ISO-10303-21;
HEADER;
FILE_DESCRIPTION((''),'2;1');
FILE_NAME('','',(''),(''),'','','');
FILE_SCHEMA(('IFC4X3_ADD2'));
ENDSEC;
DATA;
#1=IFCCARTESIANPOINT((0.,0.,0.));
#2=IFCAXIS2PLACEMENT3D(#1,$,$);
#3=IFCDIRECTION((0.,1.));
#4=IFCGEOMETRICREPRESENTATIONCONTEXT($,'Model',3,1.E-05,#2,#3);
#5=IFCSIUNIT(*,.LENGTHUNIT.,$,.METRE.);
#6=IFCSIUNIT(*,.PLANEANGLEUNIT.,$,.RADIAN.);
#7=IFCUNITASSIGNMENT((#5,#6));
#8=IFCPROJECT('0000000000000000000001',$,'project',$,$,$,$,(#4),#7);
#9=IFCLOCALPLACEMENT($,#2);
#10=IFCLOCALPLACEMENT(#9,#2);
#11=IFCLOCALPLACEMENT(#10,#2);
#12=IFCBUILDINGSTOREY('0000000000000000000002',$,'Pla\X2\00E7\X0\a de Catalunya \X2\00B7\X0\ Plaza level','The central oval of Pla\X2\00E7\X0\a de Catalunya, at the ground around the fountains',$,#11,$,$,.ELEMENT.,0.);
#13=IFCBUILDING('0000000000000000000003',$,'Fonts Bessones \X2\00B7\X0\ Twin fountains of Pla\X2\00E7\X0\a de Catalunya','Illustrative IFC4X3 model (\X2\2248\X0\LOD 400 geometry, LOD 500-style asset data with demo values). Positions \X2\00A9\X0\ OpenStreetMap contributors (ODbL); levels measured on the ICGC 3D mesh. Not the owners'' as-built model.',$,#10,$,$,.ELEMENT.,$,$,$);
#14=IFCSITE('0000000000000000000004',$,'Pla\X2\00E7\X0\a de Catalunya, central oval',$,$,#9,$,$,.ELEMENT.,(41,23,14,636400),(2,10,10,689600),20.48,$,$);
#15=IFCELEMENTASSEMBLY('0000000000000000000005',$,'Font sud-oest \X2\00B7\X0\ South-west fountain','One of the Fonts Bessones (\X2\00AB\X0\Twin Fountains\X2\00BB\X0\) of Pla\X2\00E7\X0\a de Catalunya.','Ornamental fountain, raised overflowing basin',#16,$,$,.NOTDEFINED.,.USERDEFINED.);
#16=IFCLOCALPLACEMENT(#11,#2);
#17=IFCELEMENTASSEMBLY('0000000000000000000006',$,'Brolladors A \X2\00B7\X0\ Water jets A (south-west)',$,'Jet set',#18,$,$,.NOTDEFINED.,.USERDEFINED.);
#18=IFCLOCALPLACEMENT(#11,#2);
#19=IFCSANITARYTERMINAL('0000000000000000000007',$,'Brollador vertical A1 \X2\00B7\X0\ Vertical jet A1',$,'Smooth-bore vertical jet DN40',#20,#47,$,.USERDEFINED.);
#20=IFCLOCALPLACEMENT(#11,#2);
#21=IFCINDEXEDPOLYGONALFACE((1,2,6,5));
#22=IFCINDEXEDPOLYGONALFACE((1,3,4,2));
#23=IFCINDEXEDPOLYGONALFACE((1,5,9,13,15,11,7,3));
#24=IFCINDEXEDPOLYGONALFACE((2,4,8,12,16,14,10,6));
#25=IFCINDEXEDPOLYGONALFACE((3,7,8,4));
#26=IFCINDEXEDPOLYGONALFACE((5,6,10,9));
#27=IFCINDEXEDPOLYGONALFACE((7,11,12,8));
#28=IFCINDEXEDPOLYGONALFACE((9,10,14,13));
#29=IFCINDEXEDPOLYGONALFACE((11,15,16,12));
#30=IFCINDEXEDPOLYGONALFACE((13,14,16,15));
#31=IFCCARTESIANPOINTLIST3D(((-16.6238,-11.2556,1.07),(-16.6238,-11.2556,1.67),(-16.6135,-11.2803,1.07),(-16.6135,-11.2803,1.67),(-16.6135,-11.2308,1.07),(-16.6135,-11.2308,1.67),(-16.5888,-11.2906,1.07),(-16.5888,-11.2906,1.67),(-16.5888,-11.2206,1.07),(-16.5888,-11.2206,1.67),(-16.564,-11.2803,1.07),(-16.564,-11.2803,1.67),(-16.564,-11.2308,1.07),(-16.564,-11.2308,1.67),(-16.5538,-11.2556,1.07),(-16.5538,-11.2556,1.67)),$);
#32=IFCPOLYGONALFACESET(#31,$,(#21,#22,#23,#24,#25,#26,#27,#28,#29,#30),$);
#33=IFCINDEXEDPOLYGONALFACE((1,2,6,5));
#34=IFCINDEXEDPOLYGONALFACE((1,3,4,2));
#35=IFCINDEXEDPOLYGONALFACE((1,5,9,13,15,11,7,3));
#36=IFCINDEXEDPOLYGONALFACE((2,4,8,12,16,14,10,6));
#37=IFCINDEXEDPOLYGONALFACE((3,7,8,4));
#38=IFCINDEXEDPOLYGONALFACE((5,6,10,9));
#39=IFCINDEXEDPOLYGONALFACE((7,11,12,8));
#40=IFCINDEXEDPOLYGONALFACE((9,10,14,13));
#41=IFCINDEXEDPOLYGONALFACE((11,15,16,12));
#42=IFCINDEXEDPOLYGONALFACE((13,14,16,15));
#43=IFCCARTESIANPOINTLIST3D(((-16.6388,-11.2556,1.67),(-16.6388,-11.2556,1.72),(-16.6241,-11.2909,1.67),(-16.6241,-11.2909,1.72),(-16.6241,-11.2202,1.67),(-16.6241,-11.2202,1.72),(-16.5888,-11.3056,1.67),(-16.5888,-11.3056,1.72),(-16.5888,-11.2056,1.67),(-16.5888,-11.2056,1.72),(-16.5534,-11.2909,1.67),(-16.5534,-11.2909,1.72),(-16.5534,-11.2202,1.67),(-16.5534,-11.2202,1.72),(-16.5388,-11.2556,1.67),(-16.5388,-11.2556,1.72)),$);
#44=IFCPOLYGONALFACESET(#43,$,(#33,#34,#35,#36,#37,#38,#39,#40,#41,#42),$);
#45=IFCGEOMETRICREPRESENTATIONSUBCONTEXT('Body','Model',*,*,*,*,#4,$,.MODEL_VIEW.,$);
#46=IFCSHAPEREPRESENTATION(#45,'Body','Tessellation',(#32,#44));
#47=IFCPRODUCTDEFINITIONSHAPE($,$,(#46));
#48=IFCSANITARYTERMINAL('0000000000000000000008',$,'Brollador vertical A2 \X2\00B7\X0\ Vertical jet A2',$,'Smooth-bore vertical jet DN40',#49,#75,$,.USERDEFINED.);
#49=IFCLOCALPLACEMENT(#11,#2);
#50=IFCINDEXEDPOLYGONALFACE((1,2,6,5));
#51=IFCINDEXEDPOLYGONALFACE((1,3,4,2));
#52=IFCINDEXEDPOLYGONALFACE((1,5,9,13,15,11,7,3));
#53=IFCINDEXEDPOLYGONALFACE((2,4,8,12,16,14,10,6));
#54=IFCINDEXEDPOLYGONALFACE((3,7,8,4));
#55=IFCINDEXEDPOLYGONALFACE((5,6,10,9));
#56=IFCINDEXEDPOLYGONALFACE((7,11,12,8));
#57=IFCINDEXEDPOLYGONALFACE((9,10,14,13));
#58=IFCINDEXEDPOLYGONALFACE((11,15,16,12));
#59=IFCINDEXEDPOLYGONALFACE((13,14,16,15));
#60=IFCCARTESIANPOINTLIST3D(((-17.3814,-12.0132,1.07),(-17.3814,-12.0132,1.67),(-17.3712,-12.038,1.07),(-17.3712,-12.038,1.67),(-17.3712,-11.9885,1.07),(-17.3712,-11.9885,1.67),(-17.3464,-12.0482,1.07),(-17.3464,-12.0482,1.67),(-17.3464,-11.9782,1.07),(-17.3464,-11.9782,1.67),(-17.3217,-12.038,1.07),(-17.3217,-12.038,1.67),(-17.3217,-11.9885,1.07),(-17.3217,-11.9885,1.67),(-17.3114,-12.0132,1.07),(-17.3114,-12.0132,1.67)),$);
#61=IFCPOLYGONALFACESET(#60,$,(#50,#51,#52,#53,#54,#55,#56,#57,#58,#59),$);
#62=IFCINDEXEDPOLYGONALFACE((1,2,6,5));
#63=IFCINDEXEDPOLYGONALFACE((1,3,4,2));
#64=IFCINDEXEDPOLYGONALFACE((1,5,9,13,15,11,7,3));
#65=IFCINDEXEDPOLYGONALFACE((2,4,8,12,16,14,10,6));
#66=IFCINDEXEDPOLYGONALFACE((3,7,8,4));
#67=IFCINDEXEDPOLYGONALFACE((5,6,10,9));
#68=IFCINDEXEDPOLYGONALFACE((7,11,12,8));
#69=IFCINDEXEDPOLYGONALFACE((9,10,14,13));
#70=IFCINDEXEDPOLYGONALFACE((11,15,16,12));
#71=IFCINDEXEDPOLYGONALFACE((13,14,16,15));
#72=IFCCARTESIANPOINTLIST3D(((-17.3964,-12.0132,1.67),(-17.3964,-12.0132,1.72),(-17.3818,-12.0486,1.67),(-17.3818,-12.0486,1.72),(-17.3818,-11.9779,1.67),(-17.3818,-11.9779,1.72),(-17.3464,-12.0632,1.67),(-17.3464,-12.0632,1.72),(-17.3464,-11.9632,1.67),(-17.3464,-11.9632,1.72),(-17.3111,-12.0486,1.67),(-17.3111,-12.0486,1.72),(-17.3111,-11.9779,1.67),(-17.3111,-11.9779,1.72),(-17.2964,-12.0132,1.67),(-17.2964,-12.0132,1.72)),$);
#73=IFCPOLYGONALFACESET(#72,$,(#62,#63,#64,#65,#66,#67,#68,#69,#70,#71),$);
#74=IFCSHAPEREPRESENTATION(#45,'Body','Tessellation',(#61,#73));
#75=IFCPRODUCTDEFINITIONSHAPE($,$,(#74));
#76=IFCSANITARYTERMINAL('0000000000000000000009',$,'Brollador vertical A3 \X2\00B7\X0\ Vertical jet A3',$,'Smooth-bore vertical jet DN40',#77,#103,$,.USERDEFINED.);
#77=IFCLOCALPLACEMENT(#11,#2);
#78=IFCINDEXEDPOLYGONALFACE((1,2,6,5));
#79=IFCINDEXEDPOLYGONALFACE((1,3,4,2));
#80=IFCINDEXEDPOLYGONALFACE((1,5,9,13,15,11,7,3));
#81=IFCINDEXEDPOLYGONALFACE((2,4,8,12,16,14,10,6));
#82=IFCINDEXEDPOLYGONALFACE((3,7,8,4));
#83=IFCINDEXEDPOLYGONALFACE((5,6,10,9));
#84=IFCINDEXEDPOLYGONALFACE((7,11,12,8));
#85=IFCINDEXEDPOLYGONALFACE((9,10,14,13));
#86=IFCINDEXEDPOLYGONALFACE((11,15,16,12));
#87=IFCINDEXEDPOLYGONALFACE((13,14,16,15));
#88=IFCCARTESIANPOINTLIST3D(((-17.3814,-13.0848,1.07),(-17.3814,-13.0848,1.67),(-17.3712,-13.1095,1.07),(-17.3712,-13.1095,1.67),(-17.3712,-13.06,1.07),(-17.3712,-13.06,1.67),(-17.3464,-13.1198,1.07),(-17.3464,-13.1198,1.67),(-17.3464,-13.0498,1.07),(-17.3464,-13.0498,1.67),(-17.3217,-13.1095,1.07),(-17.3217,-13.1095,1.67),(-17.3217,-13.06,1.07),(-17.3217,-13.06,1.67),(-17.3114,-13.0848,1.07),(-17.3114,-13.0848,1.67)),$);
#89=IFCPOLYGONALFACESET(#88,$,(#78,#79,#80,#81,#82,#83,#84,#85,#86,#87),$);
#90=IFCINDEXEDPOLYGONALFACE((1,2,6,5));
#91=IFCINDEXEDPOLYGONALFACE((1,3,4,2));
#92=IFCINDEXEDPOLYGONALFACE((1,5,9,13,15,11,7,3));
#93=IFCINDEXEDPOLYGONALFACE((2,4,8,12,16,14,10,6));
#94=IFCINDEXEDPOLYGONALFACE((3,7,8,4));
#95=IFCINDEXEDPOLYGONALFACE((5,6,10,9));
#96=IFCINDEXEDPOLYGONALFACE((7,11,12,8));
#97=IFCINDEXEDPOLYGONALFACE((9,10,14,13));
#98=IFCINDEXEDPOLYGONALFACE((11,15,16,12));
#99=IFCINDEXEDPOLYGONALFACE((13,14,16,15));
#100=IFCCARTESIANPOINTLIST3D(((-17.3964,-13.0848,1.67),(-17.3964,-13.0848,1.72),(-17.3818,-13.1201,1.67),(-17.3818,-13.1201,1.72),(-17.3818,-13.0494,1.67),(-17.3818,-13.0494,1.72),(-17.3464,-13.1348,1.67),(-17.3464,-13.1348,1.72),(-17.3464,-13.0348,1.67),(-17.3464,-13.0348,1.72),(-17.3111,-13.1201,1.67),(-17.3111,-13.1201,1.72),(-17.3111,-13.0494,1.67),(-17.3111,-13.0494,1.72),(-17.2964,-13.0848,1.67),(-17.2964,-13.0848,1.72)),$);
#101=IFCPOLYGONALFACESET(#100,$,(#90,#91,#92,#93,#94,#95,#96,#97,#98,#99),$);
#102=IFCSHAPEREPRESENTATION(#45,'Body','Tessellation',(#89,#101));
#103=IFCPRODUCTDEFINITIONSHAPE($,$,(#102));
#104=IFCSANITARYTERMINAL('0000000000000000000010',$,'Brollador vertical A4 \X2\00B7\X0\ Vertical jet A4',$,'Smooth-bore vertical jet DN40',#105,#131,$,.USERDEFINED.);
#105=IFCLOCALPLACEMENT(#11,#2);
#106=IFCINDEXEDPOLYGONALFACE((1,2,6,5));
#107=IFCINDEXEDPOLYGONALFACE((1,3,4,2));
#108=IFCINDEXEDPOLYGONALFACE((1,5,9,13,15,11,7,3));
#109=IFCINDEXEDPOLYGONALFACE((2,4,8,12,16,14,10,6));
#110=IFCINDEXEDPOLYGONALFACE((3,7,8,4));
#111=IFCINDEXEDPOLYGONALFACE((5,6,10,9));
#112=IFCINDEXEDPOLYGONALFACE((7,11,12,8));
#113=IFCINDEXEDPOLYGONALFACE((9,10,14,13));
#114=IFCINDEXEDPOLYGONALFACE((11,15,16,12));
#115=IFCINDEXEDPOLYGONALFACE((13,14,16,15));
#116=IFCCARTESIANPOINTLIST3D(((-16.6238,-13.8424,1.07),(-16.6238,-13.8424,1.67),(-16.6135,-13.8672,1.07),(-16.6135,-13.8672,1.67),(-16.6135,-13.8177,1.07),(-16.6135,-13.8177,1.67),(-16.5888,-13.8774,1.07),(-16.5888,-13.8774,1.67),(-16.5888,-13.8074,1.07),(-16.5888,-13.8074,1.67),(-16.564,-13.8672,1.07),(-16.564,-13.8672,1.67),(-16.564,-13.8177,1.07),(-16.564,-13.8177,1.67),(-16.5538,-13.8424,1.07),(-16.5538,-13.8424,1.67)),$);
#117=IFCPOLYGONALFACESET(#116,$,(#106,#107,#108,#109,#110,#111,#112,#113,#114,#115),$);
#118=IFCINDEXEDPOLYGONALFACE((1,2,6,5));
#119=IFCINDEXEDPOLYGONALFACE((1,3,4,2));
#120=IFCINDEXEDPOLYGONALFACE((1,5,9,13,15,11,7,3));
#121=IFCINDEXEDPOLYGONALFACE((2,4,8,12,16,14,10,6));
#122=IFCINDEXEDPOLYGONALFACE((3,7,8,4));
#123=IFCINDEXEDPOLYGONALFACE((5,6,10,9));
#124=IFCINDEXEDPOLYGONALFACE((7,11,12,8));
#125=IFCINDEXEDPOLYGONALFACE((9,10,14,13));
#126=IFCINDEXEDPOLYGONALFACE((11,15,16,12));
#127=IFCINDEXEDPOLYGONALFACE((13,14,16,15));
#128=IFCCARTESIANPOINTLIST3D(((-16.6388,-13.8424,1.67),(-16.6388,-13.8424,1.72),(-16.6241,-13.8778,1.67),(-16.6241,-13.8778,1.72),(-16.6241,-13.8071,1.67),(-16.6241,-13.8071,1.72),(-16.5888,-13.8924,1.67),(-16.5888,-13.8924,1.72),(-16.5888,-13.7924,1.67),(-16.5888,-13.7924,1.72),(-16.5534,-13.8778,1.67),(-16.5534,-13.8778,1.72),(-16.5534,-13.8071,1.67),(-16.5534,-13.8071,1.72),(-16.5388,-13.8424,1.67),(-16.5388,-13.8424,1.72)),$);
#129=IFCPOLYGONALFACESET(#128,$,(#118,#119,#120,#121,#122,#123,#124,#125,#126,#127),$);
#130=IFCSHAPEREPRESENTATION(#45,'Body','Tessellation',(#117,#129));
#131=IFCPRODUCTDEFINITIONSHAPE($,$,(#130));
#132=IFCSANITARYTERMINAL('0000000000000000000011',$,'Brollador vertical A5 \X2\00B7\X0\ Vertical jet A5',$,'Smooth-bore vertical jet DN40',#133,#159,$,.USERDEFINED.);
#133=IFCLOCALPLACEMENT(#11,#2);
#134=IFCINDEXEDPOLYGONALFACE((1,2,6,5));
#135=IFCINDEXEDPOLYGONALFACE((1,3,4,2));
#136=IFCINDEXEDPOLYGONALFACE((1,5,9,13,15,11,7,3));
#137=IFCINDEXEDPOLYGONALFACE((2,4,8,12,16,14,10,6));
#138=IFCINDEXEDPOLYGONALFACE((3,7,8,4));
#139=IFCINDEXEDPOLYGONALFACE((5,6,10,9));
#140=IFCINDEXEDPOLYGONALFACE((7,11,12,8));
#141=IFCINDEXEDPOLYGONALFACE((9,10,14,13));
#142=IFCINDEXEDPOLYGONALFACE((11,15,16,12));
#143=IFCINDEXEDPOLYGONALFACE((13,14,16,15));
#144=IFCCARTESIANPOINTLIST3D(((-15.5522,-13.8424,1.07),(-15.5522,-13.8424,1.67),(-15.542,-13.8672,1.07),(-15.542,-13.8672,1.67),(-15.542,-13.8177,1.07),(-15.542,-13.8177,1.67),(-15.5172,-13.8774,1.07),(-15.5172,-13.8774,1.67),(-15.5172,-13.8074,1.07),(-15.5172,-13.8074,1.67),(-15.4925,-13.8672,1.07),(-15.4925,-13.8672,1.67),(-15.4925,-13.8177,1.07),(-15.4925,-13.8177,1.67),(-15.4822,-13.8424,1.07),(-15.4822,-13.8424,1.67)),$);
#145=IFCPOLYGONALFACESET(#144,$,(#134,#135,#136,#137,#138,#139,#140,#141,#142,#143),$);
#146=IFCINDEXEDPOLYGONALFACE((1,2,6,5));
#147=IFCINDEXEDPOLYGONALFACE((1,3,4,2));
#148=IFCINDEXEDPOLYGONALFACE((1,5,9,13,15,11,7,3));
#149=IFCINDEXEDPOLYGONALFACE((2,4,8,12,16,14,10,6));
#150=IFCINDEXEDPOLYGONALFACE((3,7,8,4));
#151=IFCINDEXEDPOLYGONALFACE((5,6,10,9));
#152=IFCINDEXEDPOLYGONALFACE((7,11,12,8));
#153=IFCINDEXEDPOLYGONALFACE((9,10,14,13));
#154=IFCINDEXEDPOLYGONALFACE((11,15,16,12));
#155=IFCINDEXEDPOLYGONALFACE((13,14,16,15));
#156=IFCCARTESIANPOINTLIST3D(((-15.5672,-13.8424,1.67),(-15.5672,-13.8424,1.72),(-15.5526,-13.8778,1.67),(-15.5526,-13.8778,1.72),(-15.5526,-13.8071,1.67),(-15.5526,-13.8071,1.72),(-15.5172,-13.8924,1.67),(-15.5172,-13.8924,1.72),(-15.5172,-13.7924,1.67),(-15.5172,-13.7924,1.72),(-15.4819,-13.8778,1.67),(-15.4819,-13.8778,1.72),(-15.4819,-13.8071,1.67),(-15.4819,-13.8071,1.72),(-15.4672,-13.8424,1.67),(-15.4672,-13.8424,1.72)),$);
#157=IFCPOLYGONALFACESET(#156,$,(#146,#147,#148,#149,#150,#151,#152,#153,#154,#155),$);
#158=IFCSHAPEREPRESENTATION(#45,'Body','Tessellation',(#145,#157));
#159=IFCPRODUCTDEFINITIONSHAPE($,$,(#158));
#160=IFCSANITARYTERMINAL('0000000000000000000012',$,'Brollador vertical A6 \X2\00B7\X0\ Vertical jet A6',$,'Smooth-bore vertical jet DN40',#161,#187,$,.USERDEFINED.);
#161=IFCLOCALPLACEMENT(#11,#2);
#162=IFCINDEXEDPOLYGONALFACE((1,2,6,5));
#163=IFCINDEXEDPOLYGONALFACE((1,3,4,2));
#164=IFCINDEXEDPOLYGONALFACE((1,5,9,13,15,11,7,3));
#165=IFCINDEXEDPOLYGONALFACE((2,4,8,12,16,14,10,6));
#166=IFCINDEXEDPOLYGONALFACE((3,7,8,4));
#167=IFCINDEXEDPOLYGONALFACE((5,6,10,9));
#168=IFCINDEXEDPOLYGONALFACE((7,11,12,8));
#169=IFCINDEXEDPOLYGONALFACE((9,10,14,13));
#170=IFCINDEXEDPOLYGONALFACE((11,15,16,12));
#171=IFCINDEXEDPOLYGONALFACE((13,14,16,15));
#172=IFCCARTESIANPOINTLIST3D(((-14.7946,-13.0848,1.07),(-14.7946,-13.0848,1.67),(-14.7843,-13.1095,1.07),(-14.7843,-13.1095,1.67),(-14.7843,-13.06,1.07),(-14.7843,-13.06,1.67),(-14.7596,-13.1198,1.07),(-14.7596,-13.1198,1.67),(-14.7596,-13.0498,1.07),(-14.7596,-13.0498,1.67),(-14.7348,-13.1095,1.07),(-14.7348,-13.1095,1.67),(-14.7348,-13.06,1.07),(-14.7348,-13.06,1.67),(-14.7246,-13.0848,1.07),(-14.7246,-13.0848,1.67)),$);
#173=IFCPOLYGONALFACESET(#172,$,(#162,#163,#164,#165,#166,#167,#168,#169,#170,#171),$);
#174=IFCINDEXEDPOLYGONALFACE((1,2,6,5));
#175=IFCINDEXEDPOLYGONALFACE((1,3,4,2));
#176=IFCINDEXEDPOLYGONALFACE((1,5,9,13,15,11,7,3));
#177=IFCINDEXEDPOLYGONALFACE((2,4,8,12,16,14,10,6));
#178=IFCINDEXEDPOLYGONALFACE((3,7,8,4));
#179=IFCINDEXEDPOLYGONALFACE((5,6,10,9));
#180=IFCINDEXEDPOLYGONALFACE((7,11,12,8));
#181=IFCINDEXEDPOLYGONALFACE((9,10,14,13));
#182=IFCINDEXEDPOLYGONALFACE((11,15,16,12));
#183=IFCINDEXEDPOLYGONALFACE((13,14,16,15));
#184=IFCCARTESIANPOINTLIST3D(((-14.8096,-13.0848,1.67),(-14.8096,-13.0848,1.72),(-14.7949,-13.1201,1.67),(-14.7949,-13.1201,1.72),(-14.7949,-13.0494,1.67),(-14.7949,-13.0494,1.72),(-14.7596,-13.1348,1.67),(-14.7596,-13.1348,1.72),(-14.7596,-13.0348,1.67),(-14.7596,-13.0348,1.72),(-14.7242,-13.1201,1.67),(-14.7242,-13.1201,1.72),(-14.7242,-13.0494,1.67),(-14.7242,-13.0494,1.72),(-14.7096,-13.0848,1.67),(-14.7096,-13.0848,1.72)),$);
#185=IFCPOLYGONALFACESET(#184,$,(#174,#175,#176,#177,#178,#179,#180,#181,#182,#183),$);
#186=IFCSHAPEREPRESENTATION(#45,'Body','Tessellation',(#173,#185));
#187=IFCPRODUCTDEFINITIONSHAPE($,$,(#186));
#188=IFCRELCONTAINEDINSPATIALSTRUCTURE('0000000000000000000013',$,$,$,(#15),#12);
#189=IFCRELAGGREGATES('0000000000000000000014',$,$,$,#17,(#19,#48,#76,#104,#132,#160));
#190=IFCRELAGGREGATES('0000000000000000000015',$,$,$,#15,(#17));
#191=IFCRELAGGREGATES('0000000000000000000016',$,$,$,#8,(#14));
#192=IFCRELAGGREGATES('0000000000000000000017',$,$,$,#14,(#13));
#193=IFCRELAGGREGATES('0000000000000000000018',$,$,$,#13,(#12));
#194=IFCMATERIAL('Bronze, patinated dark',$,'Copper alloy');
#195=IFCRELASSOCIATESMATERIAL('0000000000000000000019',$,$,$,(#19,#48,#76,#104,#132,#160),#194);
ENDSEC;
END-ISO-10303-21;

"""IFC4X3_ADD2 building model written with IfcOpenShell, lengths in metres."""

from ifc_helpers import new_model, si_unit, direction, frame, origin, place, context, subcontext, project, spatial, polyline, outline, extrude, material, element, aggregate, save


model = new_model("IFC4X3_ADD2")

# Units and contexts
model_context = context("Model", 3, precision=1e-05, world=origin(), true_north=direction((0.0, 1.0)))
body_context = subcontext(model_context, "Body", "Model", "MODEL_VIEW")
ifc_project = project(units=[si_unit("LENGTHUNIT", "METRE"), si_unit("PLANEANGLEUNIT", "RADIAN")], contexts=[model_context])

# Site, building, storey
site_placement = place(None, origin())
site = spatial("IfcSite", under=ifc_project, at=site_placement, Name="Plaça de Catalunya, central oval", CompositionType="ELEMENT", RefLatitude=(41, 23, 14, 636400), RefLongitude=(2, 10, 10, 689600), RefElevation=20.48)
building_placement = place(site_placement, origin())
building = spatial("IfcBuilding", under=site, at=building_placement, Name="Fonts Bessones · Twin fountains of Plaça de Catalunya", Description="Illustrative IFC4X3 model (≈LOD 400 geometry, LOD 500-style asset data with demo values). Positions © OpenStreetMap contributors (ODbL); levels measured on the ICGC 3D mesh. Not the owners' as-built model.", CompositionType="ELEMENT")
storey_placement = place(building_placement, origin())
storey = spatial("IfcBuildingStorey", under=building, at=storey_placement, Name="Plaça de Catalunya · Plaza level", Description="The central oval of Plaça de Catalunya, at the ground around the fountains", CompositionType="ELEMENT", Elevation=0.0)

# Element assemblies, sanitary terminals
assembly_1_placement = place(building_placement, origin())
assembly_1 = element("IfcElementAssembly", 1, at=assembly_1_placement, inside=storey, Name="Font sud-oest · South-west fountain", Description="One of the Fonts Bessones («Twin Fountains») of Plaça de Catalunya.", ObjectType="Ornamental fountain, raised overflowing basin", AssemblyPlace="NOTDEFINED", PredefinedType="USERDEFINED")
assembly_2_placement = place(building_placement, origin())
assembly_2 = element("IfcElementAssembly", 2, at=assembly_2_placement, Name="Brolladors A · Water jets A (south-west)", ObjectType="Jet set", AssemblyPlace="NOTDEFINED", PredefinedType="USERDEFINED")
ifc_material_1 = material(Name="Bronze, patinated dark", Category="Copper alloy")
sanitary_terminal_1_placement = place(building_placement, origin())
sanitary_terminal_1 = element("IfcSanitaryTerminal", 3, at=sanitary_terminal_1_placement, material=ifc_material_1, Name="Brollador vertical A1 · Vertical jet A1", ObjectType="Smooth-bore vertical jet DN40", PredefinedType="USERDEFINED", context=body_context, shape_type="SweptSolid", body=[
    extrude(outline(polyline([(-16.5538, -11.2556), (-16.564, -11.2308), (-16.5888, -11.2206), (-16.6135, -11.2308), (-16.6238, -11.2556), (-16.6135, -11.2803), (-16.5888, -11.2906), (-16.564, -11.2803), (-16.5538, -11.2556)])), frame((0.0, 0.0, 1.07)), (0.0, 0.0, 1.0), 0.6),
    extrude(outline(polyline([(-16.5388, -11.2556), (-16.5534, -11.2202), (-16.5888, -11.2056), (-16.6241, -11.2202), (-16.6388, -11.2556), (-16.6241, -11.2909), (-16.5888, -11.3056), (-16.5534, -11.2909), (-16.5388, -11.2556)])), frame((0.0, 0.0, 1.67)), (0.0, 0.0, 1.0), 0.05),
])
sanitary_terminal_2_placement = place(building_placement, origin())
sanitary_terminal_2 = element("IfcSanitaryTerminal", 4, at=sanitary_terminal_2_placement, material=ifc_material_1, Name="Brollador vertical A2 · Vertical jet A2", ObjectType="Smooth-bore vertical jet DN40", PredefinedType="USERDEFINED", context=body_context, shape_type="SweptSolid", body=[
    extrude(outline(polyline([(-17.3114, -12.0132), (-17.3217, -11.9885), (-17.3464, -11.9782), (-17.3712, -11.9885), (-17.3814, -12.0132), (-17.3712, -12.038), (-17.3464, -12.0482), (-17.3217, -12.038), (-17.3114, -12.0132)])), frame((0.0, 0.0, 1.07)), (0.0, 0.0, 1.0), 0.6),
    extrude(outline(polyline([(-17.2964, -12.0132), (-17.3111, -11.9779), (-17.3464, -11.9632), (-17.3818, -11.9779), (-17.3964, -12.0132), (-17.3818, -12.0486), (-17.3464, -12.0632), (-17.3111, -12.0486), (-17.2964, -12.0132)])), frame((0.0, 0.0, 1.67)), (0.0, 0.0, 1.0), 0.05),
])
sanitary_terminal_3_placement = place(building_placement, origin())
sanitary_terminal_3 = element("IfcSanitaryTerminal", 5, at=sanitary_terminal_3_placement, material=ifc_material_1, Name="Brollador vertical A3 · Vertical jet A3", ObjectType="Smooth-bore vertical jet DN40", PredefinedType="USERDEFINED", context=body_context, shape_type="SweptSolid", body=[
    extrude(outline(polyline([(-17.3114, -13.0848), (-17.3217, -13.06), (-17.3464, -13.0498), (-17.3712, -13.06), (-17.3814, -13.0848), (-17.3712, -13.1095), (-17.3464, -13.1198), (-17.3217, -13.1095), (-17.3114, -13.0848)])), frame((0.0, 0.0, 1.07)), (0.0, 0.0, 1.0), 0.6),
    extrude(outline(polyline([(-17.2964, -13.0848), (-17.3111, -13.0494), (-17.3464, -13.0348), (-17.3818, -13.0494), (-17.3964, -13.0848), (-17.3818, -13.1201), (-17.3464, -13.1348), (-17.3111, -13.1201), (-17.2964, -13.0848)])), frame((0.0, 0.0, 1.67)), (0.0, 0.0, 1.0), 0.05),
])
sanitary_terminal_4_placement = place(building_placement, origin())
sanitary_terminal_4 = element("IfcSanitaryTerminal", 6, at=sanitary_terminal_4_placement, material=ifc_material_1, Name="Brollador vertical A4 · Vertical jet A4", ObjectType="Smooth-bore vertical jet DN40", PredefinedType="USERDEFINED", context=body_context, shape_type="SweptSolid", body=[
    extrude(outline(polyline([(-16.5538, -13.8424), (-16.564, -13.8177), (-16.5888, -13.8074), (-16.6135, -13.8177), (-16.6238, -13.8424), (-16.6135, -13.8672), (-16.5888, -13.8774), (-16.564, -13.8672), (-16.5538, -13.8424)])), frame((0.0, 0.0, 1.07)), (0.0, 0.0, 1.0), 0.6),
    extrude(outline(polyline([(-16.5388, -13.8424), (-16.5534, -13.8071), (-16.5888, -13.7924), (-16.6241, -13.8071), (-16.6388, -13.8424), (-16.6241, -13.8778), (-16.5888, -13.8924), (-16.5534, -13.8778), (-16.5388, -13.8424)])), frame((0.0, 0.0, 1.67)), (0.0, 0.0, 1.0), 0.05),
])
sanitary_terminal_5_placement = place(building_placement, origin())
sanitary_terminal_5 = element("IfcSanitaryTerminal", 7, at=sanitary_terminal_5_placement, material=ifc_material_1, Name="Brollador vertical A5 · Vertical jet A5", ObjectType="Smooth-bore vertical jet DN40", PredefinedType="USERDEFINED", context=body_context, shape_type="SweptSolid", body=[
    extrude(outline(polyline([(-15.4822, -13.8424), (-15.4925, -13.8177), (-15.5172, -13.8074), (-15.542, -13.8177), (-15.5522, -13.8424), (-15.542, -13.8672), (-15.5172, -13.8774), (-15.4925, -13.8672), (-15.4822, -13.8424)])), frame((0.0, 0.0, 1.07)), (0.0, 0.0, 1.0), 0.6),
    extrude(outline(polyline([(-15.4672, -13.8424), (-15.4819, -13.8071), (-15.5172, -13.7924), (-15.5526, -13.8071), (-15.5672, -13.8424), (-15.5526, -13.8778), (-15.5172, -13.8924), (-15.4819, -13.8778), (-15.4672, -13.8424)])), frame((0.0, 0.0, 1.67)), (0.0, 0.0, 1.0), 0.05),
])
sanitary_terminal_6_placement = place(building_placement, origin())
sanitary_terminal_6 = element("IfcSanitaryTerminal", 8, at=sanitary_terminal_6_placement, material=ifc_material_1, Name="Brollador vertical A6 · Vertical jet A6", ObjectType="Smooth-bore vertical jet DN40", PredefinedType="USERDEFINED", context=body_context, shape_type="SweptSolid", body=[
    extrude(outline(polyline([(-14.7246, -13.0848), (-14.7348, -13.06), (-14.7596, -13.0498), (-14.7843, -13.06), (-14.7946, -13.0848), (-14.7843, -13.1095), (-14.7596, -13.1198), (-14.7348, -13.1095), (-14.7246, -13.0848)])), frame((0.0, 0.0, 1.07)), (0.0, 0.0, 1.0), 0.6),
    extrude(outline(polyline([(-14.7096, -13.0848), (-14.7242, -13.0494), (-14.7596, -13.0348), (-14.7949, -13.0494), (-14.8096, -13.0848), (-14.7949, -13.1201), (-14.7596, -13.1348), (-14.7242, -13.1201), (-14.7096, -13.0848)])), frame((0.0, 0.0, 1.67)), (0.0, 0.0, 1.0), 0.05),
])
aggregate(assembly_2, [sanitary_terminal_1, sanitary_terminal_2, sanitary_terminal_3, sanitary_terminal_4, sanitary_terminal_5, sanitary_terminal_6])
aggregate(assembly_1, [assembly_2])

save(model, "model.ifc")
